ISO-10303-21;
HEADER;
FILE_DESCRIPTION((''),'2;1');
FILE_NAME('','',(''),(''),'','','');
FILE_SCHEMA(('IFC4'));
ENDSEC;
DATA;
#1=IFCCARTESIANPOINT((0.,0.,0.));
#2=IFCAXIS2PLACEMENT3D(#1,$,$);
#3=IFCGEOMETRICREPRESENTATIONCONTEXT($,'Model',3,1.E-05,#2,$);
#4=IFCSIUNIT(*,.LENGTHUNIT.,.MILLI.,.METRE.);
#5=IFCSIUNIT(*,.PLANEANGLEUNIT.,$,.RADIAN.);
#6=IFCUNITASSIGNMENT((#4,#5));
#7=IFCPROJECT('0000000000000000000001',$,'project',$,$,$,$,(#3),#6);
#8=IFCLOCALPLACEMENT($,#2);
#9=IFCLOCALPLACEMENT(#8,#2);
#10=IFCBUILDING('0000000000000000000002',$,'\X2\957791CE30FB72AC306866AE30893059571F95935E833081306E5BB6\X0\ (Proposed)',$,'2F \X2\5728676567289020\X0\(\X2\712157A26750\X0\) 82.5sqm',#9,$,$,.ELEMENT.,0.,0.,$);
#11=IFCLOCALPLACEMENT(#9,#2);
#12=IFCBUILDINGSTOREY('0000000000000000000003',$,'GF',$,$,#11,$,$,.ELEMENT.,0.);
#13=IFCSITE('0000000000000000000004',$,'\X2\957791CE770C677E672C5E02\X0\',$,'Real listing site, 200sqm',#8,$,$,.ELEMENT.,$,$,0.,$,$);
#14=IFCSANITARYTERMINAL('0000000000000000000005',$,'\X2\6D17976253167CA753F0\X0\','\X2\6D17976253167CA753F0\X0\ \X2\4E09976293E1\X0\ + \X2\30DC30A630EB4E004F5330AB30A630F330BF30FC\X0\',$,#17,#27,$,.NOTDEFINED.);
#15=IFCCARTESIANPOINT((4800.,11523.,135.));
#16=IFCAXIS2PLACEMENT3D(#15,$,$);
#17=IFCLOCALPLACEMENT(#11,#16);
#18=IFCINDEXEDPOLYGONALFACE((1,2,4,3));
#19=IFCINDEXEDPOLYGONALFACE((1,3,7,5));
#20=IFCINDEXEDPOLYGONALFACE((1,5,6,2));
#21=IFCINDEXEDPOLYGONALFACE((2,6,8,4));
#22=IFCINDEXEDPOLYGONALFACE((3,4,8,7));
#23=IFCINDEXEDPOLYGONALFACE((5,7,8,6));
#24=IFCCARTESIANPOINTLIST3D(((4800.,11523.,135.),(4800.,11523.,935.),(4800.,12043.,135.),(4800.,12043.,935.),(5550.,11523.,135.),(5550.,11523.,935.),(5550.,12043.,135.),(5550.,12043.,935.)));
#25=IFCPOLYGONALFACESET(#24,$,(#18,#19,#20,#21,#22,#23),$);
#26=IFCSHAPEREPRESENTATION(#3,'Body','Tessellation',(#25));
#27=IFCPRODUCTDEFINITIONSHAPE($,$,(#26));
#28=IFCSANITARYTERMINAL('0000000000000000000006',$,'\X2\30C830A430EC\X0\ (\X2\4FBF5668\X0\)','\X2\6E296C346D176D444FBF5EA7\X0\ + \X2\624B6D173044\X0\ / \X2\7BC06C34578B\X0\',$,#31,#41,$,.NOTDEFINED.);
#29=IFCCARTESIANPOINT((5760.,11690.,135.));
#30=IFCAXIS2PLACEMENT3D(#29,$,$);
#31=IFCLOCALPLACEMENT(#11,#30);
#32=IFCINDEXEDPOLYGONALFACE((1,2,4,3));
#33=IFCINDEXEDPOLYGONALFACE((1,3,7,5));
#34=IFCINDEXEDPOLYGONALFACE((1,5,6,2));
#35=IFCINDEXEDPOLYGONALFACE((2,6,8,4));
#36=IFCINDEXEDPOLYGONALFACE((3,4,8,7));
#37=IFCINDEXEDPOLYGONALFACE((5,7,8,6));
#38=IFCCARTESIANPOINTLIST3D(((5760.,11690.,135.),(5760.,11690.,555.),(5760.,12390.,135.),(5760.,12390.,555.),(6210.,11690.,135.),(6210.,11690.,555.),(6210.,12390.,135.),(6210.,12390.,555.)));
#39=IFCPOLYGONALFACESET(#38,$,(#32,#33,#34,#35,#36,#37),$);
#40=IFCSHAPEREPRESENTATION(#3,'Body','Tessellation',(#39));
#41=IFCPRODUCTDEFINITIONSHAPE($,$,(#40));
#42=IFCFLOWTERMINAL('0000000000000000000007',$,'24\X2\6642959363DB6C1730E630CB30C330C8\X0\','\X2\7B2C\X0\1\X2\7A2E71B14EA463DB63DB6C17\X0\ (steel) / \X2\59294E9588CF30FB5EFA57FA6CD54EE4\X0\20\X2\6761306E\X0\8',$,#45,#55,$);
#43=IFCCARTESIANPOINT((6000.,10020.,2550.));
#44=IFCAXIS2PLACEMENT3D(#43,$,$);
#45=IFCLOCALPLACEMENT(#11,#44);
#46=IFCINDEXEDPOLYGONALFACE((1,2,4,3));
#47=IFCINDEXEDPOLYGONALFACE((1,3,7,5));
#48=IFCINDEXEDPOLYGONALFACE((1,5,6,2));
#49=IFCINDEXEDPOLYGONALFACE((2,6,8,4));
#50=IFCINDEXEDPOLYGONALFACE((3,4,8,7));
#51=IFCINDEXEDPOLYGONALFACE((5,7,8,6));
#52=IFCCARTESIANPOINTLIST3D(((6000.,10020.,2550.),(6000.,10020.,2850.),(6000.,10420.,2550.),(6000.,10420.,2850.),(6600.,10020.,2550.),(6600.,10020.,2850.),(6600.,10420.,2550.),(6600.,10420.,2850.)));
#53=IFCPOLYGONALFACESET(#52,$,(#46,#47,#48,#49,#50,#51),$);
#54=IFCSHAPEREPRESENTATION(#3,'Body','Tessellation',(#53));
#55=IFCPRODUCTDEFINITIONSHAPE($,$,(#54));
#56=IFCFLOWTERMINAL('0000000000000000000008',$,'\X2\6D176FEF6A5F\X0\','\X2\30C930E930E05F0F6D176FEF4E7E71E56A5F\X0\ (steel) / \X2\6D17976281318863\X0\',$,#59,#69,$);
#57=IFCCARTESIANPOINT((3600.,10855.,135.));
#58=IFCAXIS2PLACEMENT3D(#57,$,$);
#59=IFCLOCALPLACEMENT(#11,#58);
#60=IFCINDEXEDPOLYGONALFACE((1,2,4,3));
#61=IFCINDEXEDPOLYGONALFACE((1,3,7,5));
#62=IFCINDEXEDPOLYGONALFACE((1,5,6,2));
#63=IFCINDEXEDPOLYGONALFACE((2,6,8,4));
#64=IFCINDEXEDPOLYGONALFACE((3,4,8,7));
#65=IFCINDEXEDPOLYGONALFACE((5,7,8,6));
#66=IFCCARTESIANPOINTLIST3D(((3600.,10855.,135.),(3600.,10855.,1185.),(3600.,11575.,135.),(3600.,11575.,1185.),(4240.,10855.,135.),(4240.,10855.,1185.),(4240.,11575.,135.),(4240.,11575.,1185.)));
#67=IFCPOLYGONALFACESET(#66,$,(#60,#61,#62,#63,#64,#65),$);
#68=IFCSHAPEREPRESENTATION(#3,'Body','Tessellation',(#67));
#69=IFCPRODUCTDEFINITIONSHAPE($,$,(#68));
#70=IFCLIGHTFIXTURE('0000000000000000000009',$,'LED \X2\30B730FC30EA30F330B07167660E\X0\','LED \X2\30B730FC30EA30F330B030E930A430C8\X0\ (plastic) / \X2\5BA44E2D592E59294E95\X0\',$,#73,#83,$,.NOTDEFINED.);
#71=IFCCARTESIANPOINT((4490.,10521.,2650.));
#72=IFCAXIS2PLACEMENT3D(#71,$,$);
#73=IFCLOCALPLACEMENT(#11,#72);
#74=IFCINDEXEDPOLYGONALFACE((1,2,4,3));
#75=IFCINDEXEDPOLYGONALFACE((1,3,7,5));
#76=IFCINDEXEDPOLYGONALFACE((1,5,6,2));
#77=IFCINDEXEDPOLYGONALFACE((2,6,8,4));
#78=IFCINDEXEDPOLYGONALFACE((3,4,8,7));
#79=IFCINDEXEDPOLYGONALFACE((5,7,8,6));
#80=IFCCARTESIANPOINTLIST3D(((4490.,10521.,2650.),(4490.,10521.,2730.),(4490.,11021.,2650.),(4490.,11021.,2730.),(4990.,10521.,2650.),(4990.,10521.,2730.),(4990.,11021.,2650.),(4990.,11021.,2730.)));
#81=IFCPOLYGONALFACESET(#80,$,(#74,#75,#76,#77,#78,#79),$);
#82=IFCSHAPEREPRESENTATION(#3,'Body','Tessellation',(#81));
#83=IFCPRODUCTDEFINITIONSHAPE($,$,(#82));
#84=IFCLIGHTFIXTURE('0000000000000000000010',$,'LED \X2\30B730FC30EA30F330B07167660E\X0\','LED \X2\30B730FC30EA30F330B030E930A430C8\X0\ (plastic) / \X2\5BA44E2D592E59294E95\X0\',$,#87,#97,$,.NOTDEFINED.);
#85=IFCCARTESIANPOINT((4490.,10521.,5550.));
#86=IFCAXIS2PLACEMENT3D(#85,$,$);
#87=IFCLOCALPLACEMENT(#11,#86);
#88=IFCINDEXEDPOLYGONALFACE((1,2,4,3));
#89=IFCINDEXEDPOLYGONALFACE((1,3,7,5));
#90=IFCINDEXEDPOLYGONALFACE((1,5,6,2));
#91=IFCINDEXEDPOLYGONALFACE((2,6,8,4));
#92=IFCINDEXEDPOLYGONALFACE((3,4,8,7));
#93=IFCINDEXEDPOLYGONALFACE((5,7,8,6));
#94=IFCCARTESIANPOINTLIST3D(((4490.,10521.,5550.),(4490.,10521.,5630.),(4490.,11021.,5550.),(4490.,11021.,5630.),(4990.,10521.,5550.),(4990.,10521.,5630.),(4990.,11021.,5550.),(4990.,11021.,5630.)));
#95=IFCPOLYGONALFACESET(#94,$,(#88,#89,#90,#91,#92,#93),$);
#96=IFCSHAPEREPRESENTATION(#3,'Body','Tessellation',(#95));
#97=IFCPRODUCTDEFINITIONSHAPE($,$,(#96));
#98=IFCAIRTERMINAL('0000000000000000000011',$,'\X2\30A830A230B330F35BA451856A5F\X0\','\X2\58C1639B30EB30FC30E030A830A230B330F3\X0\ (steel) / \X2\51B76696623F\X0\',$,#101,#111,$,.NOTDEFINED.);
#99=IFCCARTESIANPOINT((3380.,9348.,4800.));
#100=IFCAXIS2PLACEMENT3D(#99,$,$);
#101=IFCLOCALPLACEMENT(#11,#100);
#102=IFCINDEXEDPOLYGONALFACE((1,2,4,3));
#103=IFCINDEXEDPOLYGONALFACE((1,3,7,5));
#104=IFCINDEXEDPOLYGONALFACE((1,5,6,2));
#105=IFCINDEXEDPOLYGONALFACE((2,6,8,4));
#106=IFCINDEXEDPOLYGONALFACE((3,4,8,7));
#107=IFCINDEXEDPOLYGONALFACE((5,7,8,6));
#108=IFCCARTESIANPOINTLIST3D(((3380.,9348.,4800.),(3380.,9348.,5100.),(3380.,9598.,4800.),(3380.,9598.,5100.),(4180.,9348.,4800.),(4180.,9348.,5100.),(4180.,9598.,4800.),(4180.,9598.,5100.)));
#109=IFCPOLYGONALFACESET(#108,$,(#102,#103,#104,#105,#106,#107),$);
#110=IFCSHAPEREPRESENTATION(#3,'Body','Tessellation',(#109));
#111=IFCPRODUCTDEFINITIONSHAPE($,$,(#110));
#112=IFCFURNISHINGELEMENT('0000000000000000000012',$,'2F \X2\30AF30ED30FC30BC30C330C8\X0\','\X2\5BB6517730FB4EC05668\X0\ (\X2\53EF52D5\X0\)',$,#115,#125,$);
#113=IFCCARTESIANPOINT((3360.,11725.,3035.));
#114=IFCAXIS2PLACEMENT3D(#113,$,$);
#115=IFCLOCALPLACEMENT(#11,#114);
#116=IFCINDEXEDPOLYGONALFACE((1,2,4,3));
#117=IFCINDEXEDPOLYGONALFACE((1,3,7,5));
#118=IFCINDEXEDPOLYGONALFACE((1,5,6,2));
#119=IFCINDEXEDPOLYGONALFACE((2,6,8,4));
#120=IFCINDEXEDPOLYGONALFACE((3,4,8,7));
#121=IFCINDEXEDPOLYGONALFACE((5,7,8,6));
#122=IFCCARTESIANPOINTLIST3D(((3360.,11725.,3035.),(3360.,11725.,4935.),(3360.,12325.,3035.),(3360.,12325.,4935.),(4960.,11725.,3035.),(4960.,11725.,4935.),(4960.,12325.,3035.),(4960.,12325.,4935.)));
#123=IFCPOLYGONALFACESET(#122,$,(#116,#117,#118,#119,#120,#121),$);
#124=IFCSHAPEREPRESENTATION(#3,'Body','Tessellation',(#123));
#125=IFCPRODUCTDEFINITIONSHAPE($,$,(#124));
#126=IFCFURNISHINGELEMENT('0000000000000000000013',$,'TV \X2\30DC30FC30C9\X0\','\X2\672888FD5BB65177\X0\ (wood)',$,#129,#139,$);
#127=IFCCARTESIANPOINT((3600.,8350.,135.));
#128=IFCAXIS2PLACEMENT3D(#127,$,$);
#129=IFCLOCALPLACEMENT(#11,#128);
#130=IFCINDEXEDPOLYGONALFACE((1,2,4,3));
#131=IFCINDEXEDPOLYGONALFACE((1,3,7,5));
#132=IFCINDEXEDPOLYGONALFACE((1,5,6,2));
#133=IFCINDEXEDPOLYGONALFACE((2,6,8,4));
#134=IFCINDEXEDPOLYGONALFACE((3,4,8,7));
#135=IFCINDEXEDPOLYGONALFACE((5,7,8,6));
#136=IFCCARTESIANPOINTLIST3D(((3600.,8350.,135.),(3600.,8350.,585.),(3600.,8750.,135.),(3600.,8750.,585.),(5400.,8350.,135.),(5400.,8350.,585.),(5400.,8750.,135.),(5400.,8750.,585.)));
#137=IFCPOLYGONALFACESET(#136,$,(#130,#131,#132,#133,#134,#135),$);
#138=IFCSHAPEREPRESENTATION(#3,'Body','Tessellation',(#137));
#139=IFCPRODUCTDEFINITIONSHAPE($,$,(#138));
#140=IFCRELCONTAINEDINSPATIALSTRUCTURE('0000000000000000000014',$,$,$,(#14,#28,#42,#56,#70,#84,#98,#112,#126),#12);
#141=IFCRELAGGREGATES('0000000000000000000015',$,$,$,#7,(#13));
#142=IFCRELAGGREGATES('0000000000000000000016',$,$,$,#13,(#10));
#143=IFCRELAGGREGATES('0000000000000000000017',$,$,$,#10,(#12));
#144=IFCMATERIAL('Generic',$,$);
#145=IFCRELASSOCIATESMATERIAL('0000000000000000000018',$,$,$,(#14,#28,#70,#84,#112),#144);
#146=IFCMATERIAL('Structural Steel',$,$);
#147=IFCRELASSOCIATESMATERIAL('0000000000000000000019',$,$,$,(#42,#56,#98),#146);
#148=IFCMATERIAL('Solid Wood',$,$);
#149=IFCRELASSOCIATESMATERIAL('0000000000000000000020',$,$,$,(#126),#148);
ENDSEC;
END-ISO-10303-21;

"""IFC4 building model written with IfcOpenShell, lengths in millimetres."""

from ifc_helpers import new_model, si_unit, frame, frame_2d, origin, place, context, project, spatial, rectangle, extrude, material, element, save


model = new_model("IFC4")

# Units and contexts
model_context = context("Model", 3, precision=1e-05, world=origin())
ifc_project = project(units=[si_unit("LENGTHUNIT", "METRE", prefix="MILLI"), si_unit("PLANEANGLEUNIT", "RADIAN")], contexts=[model_context])

# Site, building, storey
site_placement = place(None, origin())
site = spatial("IfcSite", under=ifc_project, at=site_placement, Name="長野県松本市", ObjectType="Real listing site, 200sqm", CompositionType="ELEMENT", RefElevation=0.0)
building_placement = place(site_placement, origin())
building = spatial("IfcBuilding", under=site, at=building_placement, Name="長野・犬と暮らす土間広めの家 (Proposed)", ObjectType="2F 在来木造(無垢材) 82.5sqm", CompositionType="ELEMENT", ElevationOfRefHeight=0.0, ElevationOfTerrain=0.0)
storey_placement = place(building_placement, origin())
storey = spatial("IfcBuildingStorey", under=building, at=storey_placement, Name="GF", CompositionType="ELEMENT", Elevation=0.0)

# Shared definitions
ifc_material_1 = material(Name="Solid Wood")

# Sanitary terminals
ifc_material_2 = material(Name="Generic")
sanitary_terminal_1_placement = place(storey_placement, frame((4800.0, 11523.0, 135.0)))
element("IfcSanitaryTerminal", 1, at=sanitary_terminal_1_placement, inside=storey, material=ifc_material_2, Name="洗面化粧台", Description="洗面化粧台 三面鏡 + ボウル一体カウンター", PredefinedType="NOTDEFINED", context=model_context, shape_type="SweptSolid", body=[
    extrude(rectangle(XDim=750.0, YDim=520.0, at=frame_2d((375.0, 260.0))), frame((4800.0, 11523.0, 135.0)), (0.0, 0.0, 1.0), 800.0),
])
sanitary_terminal_2_placement = place(storey_placement, frame((5760.0, 11690.0, 135.0)))
element("IfcSanitaryTerminal", 2, at=sanitary_terminal_2_placement, inside=storey, material=ifc_material_2, Name="トイレ (便器)", Description="温水洗浄便座 + 手洗い / 節水型", PredefinedType="NOTDEFINED", context=model_context, shape_type="SweptSolid", body=[
    extrude(rectangle(XDim=450.0, YDim=700.0, at=frame_2d((225.0, 350.0))), frame((5760.0, 11690.0, 135.0)), (0.0, 0.0, 1.0), 420.0),
])

# Flow terminals
ifc_material_3 = material(Name="Structural Steel")
flow_terminal_1_placement = place(storey_placement, frame((6000.0, 10020.0, 2550.0)))
element("IfcFlowTerminal", 3, at=flow_terminal_1_placement, inside=storey, material=ifc_material_3, Name="24時間換気ユニット", Description="第1種熱交換換気 (steel) / 天井裏・建基法令20条の8", context=model_context, shape_type="SweptSolid", body=[
    extrude(rectangle(XDim=600.0, YDim=400.0, at=frame_2d((300.0, 200.0))), frame((6000.0, 10020.0, 2550.0)), (0.0, 0.0, 1.0), 300.0),
])
flow_terminal_2_placement = place(storey_placement, frame((3600.0, 10855.0, 135.0)))
element("IfcFlowTerminal", 4, at=flow_terminal_2_placement, inside=storey, material=ifc_material_3, Name="洗濯機", Description="ドラム式洗濯乾燥機 (steel) / 洗面脱衣", context=model_context, shape_type="SweptSolid", body=[
    extrude(rectangle(XDim=640.0, YDim=720.0, at=frame_2d((320.0, 360.0))), frame((3600.0, 10855.0, 135.0)), (0.0, 0.0, 1.0), 1050.0),
])

# Light fixtures
light_fixture_1_placement = place(storey_placement, frame((4490.0, 10521.0, 2650.0)))
element("IfcLightFixture", 5, at=light_fixture_1_placement, inside=storey, material=ifc_material_2, Name="LED シーリング照明", Description="LED シーリングライト (plastic) / 室中央天井", PredefinedType="NOTDEFINED", context=model_context, shape_type="SweptSolid", body=[
    extrude(rectangle(XDim=500.0, YDim=500.0, at=frame_2d((250.0, 250.0))), frame((4490.0, 10521.0, 2650.0)), (0.0, 0.0, 1.0), 80.0),
])
light_fixture_2_placement = place(storey_placement, frame((4490.0, 10521.0, 5550.0)))
element("IfcLightFixture", 6, at=light_fixture_2_placement, inside=storey, material=ifc_material_2, Name="LED シーリング照明", Description="LED シーリングライト (plastic) / 室中央天井", PredefinedType="NOTDEFINED", context=model_context, shape_type="SweptSolid", body=[
    extrude(rectangle(XDim=500.0, YDim=500.0, at=frame_2d((250.0, 250.0))), frame((4490.0, 10521.0, 5550.0)), (0.0, 0.0, 1.0), 80.0),
])

# Air terminal
air_terminal_placement = place(storey_placement, frame((3380.0, 9348.0, 4800.0)))
element("IfcAirTerminal", 7, at=air_terminal_placement, inside=storey, material=ifc_material_3, Name="エアコン室内機", Description="壁掛ルームエアコン (steel) / 冷暖房", PredefinedType="NOTDEFINED", context=model_context, shape_type="SweptSolid", body=[
    extrude(rectangle(XDim=800.0, YDim=250.0, at=frame_2d((400.0, 125.0))), frame((3380.0, 9348.0, 4800.0)), (0.0, 0.0, 1.0), 300.0),
])

# Furnishing elements
furnishing_1_placement = place(storey_placement, frame((3360.0, 11725.0, 3035.0)))
element("IfcFurnishingElement", 8, at=furnishing_1_placement, inside=storey, material=ifc_material_2, Name="2F クローゼット", Description="家具・什器 (可動)", context=model_context, shape_type="SweptSolid", body=[
    extrude(rectangle(XDim=1600.0, YDim=600.0, at=frame_2d((800.0, 300.0))), frame((3360.0, 11725.0, 3035.0)), (0.0, 0.0, 1.0), 1900.0),
])
furnishing_2_placement = place(storey_placement, frame((3600.0, 8350.0, 135.0)))
element("IfcFurnishingElement", 9, at=furnishing_2_placement, inside=storey, material=ifc_material_1, Name="TV ボード", Description="木製家具 (wood)", context=model_context, shape_type="SweptSolid", body=[
    extrude(rectangle(XDim=1800.0, YDim=400.0, at=frame_2d((900.0, 200.0))), frame((3600.0, 8350.0, 135.0)), (0.0, 0.0, 1.0), 450.0),
])

save(model, "model.ifc")
